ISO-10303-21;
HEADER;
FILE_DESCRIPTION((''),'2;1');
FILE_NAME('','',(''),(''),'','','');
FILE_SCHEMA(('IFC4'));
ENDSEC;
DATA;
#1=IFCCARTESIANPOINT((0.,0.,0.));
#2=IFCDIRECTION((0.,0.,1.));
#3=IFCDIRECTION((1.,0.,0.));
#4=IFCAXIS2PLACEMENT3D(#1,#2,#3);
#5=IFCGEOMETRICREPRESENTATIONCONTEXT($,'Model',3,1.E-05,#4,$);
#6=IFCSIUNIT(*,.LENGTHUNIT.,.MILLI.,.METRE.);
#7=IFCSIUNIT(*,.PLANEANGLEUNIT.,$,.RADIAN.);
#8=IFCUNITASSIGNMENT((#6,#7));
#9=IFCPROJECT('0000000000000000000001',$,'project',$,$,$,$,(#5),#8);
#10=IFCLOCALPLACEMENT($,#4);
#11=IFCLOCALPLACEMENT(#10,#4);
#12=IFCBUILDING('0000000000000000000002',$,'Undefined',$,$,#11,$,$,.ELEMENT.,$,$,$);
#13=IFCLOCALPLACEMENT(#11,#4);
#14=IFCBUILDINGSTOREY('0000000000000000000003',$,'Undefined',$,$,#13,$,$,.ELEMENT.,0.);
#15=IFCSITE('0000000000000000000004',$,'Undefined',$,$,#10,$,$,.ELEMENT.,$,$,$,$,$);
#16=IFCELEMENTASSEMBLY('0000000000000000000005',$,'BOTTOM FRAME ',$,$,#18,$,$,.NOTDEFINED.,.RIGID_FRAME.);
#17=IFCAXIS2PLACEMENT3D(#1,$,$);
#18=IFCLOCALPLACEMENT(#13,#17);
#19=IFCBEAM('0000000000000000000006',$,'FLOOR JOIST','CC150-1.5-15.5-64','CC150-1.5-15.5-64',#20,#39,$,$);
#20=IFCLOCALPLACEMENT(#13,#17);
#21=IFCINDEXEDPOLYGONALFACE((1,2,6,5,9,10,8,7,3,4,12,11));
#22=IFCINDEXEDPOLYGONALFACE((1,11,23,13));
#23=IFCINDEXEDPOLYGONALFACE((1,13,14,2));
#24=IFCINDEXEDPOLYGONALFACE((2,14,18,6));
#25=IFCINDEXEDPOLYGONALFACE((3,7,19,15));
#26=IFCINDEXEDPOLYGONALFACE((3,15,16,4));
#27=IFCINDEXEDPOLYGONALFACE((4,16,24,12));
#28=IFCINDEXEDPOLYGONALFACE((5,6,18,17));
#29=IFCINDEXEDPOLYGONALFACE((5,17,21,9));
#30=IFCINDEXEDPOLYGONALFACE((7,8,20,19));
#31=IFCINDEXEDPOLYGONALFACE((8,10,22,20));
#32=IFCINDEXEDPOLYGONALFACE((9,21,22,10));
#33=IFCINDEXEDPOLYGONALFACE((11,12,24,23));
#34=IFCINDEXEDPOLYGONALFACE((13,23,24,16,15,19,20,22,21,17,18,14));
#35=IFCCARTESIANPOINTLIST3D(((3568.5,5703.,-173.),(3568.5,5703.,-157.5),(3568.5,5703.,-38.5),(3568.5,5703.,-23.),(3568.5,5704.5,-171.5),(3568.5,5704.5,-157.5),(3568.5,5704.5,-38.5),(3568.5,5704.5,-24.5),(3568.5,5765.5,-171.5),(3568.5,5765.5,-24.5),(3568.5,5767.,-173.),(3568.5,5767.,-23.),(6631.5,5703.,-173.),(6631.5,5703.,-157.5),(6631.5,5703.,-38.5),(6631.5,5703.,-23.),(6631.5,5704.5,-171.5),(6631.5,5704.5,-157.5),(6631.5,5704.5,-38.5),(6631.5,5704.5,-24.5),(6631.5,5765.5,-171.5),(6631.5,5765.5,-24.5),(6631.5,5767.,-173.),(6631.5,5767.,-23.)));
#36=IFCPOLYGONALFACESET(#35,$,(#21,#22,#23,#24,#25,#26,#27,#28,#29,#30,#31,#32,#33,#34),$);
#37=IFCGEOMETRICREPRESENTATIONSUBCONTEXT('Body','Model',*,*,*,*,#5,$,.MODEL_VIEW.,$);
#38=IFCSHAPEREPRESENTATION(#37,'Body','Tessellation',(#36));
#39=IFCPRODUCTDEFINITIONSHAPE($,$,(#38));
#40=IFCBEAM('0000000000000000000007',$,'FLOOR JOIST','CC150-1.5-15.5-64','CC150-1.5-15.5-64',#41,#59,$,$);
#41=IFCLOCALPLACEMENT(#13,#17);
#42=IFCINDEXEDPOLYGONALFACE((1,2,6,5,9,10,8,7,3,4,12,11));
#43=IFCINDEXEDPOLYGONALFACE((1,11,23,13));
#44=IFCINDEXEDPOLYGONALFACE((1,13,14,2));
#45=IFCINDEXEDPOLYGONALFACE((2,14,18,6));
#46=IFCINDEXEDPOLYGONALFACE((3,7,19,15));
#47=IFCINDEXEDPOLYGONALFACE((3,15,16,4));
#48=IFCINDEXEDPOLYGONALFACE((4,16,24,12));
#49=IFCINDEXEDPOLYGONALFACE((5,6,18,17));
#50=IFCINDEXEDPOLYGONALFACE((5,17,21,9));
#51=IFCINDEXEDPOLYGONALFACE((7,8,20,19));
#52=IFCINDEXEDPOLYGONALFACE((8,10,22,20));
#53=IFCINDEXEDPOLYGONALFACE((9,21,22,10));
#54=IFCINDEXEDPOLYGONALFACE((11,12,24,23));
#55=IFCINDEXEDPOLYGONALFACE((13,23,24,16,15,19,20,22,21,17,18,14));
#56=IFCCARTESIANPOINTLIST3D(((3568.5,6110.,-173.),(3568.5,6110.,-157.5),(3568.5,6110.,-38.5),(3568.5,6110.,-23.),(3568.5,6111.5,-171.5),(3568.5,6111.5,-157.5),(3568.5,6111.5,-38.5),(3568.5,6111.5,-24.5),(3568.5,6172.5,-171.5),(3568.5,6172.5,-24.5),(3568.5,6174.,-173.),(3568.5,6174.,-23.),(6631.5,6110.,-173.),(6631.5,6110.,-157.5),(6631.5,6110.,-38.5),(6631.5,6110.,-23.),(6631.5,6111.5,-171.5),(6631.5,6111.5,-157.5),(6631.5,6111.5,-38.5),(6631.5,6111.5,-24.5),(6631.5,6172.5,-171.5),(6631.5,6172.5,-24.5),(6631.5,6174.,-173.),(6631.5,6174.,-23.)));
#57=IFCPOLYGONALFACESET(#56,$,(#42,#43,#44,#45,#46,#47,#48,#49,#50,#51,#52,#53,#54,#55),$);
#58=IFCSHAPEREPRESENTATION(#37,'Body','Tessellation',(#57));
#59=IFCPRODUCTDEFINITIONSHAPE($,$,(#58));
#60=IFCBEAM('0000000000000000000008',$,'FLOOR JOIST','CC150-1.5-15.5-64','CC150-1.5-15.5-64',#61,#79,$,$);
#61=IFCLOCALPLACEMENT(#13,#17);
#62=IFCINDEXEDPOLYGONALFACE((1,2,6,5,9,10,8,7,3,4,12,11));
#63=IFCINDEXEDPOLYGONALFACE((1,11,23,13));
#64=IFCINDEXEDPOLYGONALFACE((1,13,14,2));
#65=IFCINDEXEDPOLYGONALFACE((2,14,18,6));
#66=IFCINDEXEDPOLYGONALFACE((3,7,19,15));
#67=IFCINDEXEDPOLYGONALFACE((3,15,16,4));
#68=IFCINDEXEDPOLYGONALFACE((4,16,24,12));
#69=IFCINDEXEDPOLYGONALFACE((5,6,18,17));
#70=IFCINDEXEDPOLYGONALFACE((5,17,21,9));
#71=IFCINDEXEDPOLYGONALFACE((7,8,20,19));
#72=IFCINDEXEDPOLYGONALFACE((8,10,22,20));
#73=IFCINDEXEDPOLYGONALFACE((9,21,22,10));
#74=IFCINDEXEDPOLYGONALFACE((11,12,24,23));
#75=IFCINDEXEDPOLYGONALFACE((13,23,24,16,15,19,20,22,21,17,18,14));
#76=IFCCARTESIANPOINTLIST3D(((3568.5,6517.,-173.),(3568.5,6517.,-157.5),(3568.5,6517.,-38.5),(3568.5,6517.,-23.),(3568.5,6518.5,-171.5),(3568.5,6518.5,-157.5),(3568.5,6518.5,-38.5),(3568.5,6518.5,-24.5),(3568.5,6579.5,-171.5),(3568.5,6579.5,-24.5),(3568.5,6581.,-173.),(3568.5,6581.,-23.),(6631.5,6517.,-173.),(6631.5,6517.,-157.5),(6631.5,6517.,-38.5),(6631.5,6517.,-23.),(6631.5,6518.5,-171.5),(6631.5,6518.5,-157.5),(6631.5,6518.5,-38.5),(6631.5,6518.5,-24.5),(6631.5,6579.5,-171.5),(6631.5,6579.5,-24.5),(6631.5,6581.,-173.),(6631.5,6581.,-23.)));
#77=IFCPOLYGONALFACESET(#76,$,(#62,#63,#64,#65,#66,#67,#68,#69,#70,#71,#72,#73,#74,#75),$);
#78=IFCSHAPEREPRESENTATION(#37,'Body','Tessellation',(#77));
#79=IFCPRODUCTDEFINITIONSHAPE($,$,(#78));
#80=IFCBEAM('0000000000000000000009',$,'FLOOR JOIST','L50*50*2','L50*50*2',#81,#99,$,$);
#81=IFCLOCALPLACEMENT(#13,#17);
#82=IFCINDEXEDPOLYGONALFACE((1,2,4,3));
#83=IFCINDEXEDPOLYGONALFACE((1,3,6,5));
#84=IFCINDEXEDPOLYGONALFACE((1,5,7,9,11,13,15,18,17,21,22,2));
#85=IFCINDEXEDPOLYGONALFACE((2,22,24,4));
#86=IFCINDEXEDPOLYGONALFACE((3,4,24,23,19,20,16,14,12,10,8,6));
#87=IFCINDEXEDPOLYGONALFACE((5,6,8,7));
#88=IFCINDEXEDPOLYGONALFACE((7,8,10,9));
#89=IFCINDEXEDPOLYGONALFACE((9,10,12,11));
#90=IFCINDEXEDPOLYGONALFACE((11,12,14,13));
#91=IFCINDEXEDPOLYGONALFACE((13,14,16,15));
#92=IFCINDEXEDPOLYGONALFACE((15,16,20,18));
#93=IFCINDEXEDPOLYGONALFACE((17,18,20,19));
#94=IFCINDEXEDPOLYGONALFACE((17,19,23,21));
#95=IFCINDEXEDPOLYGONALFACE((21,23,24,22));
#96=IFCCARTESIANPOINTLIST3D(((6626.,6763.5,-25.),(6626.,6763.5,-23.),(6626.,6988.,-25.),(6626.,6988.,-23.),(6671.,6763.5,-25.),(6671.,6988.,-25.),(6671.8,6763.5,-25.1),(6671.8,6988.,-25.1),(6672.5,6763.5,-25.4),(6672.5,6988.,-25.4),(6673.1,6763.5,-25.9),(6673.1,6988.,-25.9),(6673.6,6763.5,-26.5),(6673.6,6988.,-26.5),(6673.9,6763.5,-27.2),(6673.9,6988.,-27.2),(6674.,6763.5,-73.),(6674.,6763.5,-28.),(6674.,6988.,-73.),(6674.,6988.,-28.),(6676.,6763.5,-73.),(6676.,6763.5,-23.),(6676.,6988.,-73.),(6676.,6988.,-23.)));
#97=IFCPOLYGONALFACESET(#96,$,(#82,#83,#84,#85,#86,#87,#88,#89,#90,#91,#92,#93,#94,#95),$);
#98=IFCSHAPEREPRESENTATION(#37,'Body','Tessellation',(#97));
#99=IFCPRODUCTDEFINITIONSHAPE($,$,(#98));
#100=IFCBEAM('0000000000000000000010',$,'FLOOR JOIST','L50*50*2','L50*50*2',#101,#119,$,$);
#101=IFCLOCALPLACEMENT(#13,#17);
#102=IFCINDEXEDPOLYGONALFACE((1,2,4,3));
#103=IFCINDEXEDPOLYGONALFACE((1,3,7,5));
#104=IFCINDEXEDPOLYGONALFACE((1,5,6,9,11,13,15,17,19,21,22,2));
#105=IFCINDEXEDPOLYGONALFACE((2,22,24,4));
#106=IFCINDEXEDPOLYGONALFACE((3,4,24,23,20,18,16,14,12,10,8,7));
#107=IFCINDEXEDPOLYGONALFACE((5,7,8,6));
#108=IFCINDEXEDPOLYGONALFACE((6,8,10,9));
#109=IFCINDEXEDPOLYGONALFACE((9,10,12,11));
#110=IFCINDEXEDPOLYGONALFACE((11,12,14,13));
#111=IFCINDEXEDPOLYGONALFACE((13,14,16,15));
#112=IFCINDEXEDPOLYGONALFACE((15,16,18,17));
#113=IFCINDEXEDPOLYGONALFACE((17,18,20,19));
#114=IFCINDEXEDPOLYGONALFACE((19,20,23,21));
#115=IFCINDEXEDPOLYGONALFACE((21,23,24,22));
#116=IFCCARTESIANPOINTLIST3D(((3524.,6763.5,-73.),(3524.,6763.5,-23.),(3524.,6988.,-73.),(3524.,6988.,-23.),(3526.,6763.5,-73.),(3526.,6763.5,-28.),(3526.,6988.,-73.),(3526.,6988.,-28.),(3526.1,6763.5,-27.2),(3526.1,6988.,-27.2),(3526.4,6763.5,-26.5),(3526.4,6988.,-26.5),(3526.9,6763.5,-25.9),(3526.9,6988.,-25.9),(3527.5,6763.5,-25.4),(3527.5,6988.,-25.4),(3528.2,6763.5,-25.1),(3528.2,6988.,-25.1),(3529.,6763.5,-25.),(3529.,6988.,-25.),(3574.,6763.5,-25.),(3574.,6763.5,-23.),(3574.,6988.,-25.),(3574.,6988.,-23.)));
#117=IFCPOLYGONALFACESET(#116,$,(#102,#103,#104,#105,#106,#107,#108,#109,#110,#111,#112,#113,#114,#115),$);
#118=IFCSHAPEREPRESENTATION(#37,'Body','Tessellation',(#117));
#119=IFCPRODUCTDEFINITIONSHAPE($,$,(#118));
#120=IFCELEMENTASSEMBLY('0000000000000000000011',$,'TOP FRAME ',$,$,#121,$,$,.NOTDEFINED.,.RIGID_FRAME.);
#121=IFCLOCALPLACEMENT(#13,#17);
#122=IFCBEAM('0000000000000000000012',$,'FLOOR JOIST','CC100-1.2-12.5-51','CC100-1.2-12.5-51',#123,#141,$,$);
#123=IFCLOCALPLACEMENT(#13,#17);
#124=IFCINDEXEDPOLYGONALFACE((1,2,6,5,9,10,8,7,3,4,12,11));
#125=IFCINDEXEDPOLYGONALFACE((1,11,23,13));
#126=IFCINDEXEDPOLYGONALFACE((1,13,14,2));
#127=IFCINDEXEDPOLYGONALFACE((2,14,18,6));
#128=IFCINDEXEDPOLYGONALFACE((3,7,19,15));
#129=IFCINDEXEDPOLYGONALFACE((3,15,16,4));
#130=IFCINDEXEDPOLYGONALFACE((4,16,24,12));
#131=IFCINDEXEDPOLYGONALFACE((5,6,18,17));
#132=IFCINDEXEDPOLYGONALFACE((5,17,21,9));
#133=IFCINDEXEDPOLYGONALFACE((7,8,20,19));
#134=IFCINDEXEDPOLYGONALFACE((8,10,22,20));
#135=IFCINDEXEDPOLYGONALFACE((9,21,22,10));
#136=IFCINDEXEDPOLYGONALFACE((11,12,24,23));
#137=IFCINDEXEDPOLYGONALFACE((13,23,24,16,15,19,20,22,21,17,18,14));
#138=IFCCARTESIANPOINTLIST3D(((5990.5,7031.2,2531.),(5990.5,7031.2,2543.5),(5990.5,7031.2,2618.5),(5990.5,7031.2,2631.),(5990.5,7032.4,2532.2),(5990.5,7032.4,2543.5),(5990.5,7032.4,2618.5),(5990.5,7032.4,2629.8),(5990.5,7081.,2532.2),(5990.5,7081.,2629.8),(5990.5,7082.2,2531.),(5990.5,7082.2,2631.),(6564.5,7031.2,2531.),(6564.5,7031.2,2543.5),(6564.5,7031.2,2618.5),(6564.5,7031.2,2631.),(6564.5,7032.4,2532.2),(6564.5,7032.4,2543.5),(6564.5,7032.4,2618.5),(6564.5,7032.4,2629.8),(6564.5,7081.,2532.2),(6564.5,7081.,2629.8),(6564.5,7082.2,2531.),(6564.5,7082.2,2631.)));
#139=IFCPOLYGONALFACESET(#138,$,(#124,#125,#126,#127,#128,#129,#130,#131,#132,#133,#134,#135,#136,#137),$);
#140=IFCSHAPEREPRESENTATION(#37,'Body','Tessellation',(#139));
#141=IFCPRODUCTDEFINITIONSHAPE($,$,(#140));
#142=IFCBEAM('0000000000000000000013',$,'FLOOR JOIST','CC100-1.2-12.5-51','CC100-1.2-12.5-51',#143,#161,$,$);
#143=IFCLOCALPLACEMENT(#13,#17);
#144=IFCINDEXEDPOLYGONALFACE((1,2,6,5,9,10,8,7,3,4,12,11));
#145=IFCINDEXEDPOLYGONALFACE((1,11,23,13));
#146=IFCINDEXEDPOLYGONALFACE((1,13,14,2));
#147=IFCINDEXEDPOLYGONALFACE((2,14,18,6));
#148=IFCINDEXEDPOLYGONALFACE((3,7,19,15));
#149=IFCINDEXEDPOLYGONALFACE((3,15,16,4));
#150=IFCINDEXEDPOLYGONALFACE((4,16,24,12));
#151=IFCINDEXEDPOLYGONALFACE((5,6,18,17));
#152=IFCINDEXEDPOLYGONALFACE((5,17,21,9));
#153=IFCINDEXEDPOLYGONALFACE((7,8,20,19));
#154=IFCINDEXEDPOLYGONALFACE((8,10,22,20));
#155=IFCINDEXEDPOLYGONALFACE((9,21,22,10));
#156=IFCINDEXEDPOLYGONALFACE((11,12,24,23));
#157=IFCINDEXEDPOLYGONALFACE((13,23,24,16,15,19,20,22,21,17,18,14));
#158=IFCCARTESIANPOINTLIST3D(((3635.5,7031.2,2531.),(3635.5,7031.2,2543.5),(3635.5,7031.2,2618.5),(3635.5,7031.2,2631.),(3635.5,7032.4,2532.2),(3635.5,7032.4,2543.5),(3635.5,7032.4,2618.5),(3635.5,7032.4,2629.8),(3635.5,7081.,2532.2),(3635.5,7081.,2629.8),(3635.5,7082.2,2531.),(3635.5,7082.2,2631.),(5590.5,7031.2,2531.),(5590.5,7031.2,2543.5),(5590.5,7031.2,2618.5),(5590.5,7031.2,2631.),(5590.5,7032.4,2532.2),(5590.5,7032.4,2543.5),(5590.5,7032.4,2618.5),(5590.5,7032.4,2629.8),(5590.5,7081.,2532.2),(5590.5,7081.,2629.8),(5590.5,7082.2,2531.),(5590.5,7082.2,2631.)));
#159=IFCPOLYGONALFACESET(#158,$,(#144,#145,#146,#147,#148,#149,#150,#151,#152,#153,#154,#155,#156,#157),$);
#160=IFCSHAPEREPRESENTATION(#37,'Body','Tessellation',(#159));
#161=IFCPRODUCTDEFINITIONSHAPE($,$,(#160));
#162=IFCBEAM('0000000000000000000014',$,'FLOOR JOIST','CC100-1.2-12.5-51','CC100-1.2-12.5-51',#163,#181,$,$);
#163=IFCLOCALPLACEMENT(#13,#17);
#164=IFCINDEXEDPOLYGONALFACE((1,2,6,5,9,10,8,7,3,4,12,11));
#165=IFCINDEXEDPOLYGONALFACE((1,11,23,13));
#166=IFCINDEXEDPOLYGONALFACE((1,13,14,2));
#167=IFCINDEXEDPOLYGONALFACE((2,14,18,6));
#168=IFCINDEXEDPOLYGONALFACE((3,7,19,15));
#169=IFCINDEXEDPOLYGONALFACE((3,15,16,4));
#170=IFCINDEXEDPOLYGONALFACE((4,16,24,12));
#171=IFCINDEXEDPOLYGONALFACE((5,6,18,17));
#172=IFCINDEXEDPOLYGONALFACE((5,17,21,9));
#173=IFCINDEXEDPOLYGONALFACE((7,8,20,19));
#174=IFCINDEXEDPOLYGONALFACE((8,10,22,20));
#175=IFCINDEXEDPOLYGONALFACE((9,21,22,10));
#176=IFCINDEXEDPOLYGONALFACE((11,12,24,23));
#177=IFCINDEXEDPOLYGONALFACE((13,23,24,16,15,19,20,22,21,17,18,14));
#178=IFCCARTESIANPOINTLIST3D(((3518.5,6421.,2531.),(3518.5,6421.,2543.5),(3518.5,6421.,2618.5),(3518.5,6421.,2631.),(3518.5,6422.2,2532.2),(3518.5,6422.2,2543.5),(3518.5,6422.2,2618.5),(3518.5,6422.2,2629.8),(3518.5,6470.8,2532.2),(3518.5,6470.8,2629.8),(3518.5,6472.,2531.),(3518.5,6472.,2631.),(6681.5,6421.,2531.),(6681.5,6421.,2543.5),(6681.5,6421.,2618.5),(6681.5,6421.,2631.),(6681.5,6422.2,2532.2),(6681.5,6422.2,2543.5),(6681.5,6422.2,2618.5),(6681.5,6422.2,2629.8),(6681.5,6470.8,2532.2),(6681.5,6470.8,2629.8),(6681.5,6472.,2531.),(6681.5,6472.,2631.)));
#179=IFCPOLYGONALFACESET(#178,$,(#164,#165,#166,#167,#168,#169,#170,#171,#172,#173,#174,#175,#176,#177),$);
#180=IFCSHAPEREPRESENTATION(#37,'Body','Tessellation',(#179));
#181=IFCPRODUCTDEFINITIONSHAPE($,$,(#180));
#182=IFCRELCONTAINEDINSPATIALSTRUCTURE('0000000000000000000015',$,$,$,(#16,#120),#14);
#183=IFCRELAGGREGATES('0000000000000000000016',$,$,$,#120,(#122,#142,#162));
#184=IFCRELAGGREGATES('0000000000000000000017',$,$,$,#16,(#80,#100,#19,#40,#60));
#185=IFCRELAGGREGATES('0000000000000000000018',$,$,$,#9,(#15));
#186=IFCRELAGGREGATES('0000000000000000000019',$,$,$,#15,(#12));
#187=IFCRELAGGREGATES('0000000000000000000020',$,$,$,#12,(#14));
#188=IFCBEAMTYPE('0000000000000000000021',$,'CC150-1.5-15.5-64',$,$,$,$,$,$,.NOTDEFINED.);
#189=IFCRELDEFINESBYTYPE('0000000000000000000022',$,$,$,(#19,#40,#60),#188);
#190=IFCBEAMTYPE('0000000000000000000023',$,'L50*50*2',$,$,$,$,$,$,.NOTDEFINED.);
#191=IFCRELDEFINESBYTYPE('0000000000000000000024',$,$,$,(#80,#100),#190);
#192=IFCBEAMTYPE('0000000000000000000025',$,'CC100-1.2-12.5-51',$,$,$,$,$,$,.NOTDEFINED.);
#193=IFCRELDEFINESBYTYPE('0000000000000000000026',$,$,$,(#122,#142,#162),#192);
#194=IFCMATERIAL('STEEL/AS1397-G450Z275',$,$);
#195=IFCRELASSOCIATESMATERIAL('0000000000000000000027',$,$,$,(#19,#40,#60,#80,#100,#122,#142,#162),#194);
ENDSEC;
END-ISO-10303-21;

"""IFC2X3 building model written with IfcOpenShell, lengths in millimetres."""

from ifc_helpers import new_model, si_unit, frame, origin_with_axes, origin_2d_with_axis, place, context, subcontext, project, spatial, l_section, c_section, extrude, material, type_object, element, aggregate, save


model = new_model("IFC2X3")

# Units and contexts
model_context = context("Model", 3, precision=1e-05, world=origin_with_axes())
body_context = subcontext(model_context, "Body", "Model", "MODEL_VIEW")
ifc_project = project(units=[si_unit("LENGTHUNIT", "METRE", prefix="MILLI"), si_unit("PLANEANGLEUNIT", "RADIAN")], contexts=[model_context])

# Site, building, storey
site_placement = place(None, origin_with_axes())
site = spatial("IfcSite", under=ifc_project, at=site_placement, Name="Undefined", CompositionType="ELEMENT")
building_placement = place(site_placement, origin_with_axes())
building = spatial("IfcBuilding", under=site, at=building_placement, Name="Undefined", CompositionType="ELEMENT")
storey_placement = place(building_placement, origin_with_axes())
storey = spatial("IfcBuildingStorey", under=building, at=storey_placement, Name="Undefined", CompositionType="ELEMENT", Elevation=0.0)

# Element assemblies, beams
assembly_1_placement = place(storey_placement, origin_with_axes())
assembly_1 = element("IfcElementAssembly", 1, at=assembly_1_placement, inside=storey, Name="BOTTOM FRAME ", AssemblyPlace="NOTDEFINED", PredefinedType="RIGID_FRAME")
ifc_material_1 = material(Name="STEEL/AS1397-G450Z275")
beam_type_1 = type_object("IfcBeamType", Name="CC150-1.5-15.5-64", PredefinedType="NOTDEFINED")
beam_1_placement = place(assembly_1_placement, frame((3568.5, 5735.0, -98.0), z_axis=(0.0, 0.0, 1.0), x_axis=(1.0, 0.0, 0.0)))
beam_1 = element("IfcBeam", 2, at=beam_1_placement, type_object=beam_type_1, material=ifc_material_1, Name="FLOOR JOIST", Description="CC150-1.5-15.5-64", ObjectType="CC150-1.5-15.5-64", context=body_context, shape_type="SweptSolid", body=[
    extrude(c_section(Depth=150.0, Width=64.0, WallThickness=1.5, Girth=15.5, at=origin_2d_with_axis()), frame((3063.0, 0.0, 0.0), z_axis=(-1.0, 0.0, 0.0), x_axis=(0.0, -1.0, 0.0)), (0.0, 0.0, 1.0), 3063.0),
])
beam_2_placement = place(assembly_1_placement, frame((3568.5, 6142.0, -98.0), z_axis=(0.0, 0.0, 1.0), x_axis=(1.0, 0.0, 0.0)))
beam_2 = element("IfcBeam", 3, at=beam_2_placement, type_object=beam_type_1, material=ifc_material_1, Name="FLOOR JOIST", Description="CC150-1.5-15.5-64", ObjectType="CC150-1.5-15.5-64", context=body_context, shape_type="SweptSolid", body=[
    extrude(c_section(Depth=150.0, Width=64.0, WallThickness=1.5, Girth=15.5, at=origin_2d_with_axis()), frame((3063.0, 0.0, 0.0), z_axis=(-1.0, 0.0, 0.0), x_axis=(0.0, -1.0, 0.0)), (0.0, 0.0, 1.0), 3063.0),
])
beam_3_placement = place(assembly_1_placement, frame((3568.5, 6549.0, -98.0), z_axis=(0.0, 0.0, 1.0), x_axis=(1.0, 0.0, 0.0)))
beam_3 = element("IfcBeam", 4, at=beam_3_placement, type_object=beam_type_1, material=ifc_material_1, Name="FLOOR JOIST", Description="CC150-1.5-15.5-64", ObjectType="CC150-1.5-15.5-64", context=body_context, shape_type="SweptSolid", body=[
    extrude(c_section(Depth=150.0, Width=64.0, WallThickness=1.5, Girth=15.5, at=origin_2d_with_axis()), frame((3063.0, 0.0, 0.0), z_axis=(-1.0, 0.0, 0.0), x_axis=(0.0, -1.0, 0.0)), (0.0, 0.0, 1.0), 3063.0),
])
beam_type_2 = type_object("IfcBeamType", Name="L50*50*2", PredefinedType="NOTDEFINED")
beam_4_placement = place(assembly_1_placement, frame((6651.0, 6988.0, -48.0), z_axis=(-1.0, 0.0, 0.0), x_axis=(0.0, -1.0, 0.0)))
beam_4 = element("IfcBeam", 5, at=beam_4_placement, type_object=beam_type_2, material=ifc_material_1, Name="FLOOR JOIST", Description="L50*50*2", ObjectType="L50*50*2", context=body_context, shape_type="SweptSolid", body=[
    extrude(l_section(Depth=50.0, Width=50.0, Thickness=2.0, FilletRadius=3.0, at=origin_2d_with_axis()), frame((224.5, 0.0, 0.0), z_axis=(-1.0, 0.0, 0.0), x_axis=(0.0, -1.0, 0.0)), (0.0, 0.0, 1.0), 224.5),
])
beam_5_placement = place(assembly_1_placement, frame((3549.0, 6763.5, -48.0), z_axis=(1.0, 0.0, 0.0), x_axis=(0.0, 1.0, 0.0)))
beam_5 = element("IfcBeam", 6, at=beam_5_placement, type_object=beam_type_2, material=ifc_material_1, Name="FLOOR JOIST", Description="L50*50*2", ObjectType="L50*50*2", context=body_context, shape_type="SweptSolid", body=[
    extrude(l_section(Depth=50.0, Width=50.0, Thickness=2.0, FilletRadius=3.0, at=origin_2d_with_axis()), frame((224.5, 0.0, 0.0), z_axis=(-1.0, 0.0, 0.0), x_axis=(0.0, -1.0, 0.0)), (0.0, 0.0, 1.0), 224.5),
])
assembly_2_placement = place(storey_placement, origin_with_axes())
assembly_2 = element("IfcElementAssembly", 7, at=assembly_2_placement, inside=storey, Name="TOP FRAME ", AssemblyPlace="NOTDEFINED", PredefinedType="RIGID_FRAME")
beam_type_3 = type_object("IfcBeamType", Name="CC100-1.2-12.5-51", PredefinedType="NOTDEFINED")
beam_6_placement = place(assembly_2_placement, frame((5990.5, 7056.7, 2581.0), z_axis=(0.0, 0.0, 1.0), x_axis=(1.0, 0.0, 0.0)))
beam_6 = element("IfcBeam", 8, at=beam_6_placement, type_object=beam_type_3, material=ifc_material_1, Name="FLOOR JOIST", Description="CC100-1.2-12.5-51", ObjectType="CC100-1.2-12.5-51", context=body_context, shape_type="SweptSolid", body=[
    extrude(c_section(Depth=100.0, Width=51.0, WallThickness=1.2, Girth=12.5, at=origin_2d_with_axis()), frame((574.0, 0.0, 0.0), z_axis=(-1.0, 0.0, 0.0), x_axis=(0.0, -1.0, 0.0)), (0.0, 0.0, 1.0), 574.0),
])
beam_7_placement = place(assembly_2_placement, frame((3635.5, 7056.7, 2581.0), z_axis=(0.0, 0.0, 1.0), x_axis=(1.0, 0.0, 0.0)))
beam_7 = element("IfcBeam", 9, at=beam_7_placement, type_object=beam_type_3, material=ifc_material_1, Name="FLOOR JOIST", Description="CC100-1.2-12.5-51", ObjectType="CC100-1.2-12.5-51", context=body_context, shape_type="SweptSolid", body=[
    extrude(c_section(Depth=100.0, Width=51.0, WallThickness=1.2, Girth=12.5, at=origin_2d_with_axis()), frame((1955.0, 0.0, 0.0), z_axis=(-1.0, 0.0, 0.0), x_axis=(0.0, -1.0, 0.0)), (0.0, 0.0, 1.0), 1955.0),
])
beam_8_placement = place(assembly_2_placement, frame((3518.5, 6446.5, 2581.0), z_axis=(0.0, 0.0, 1.0), x_axis=(1.0, 0.0, 0.0)))
beam_8 = element("IfcBeam", 10, at=beam_8_placement, type_object=beam_type_3, material=ifc_material_1, Name="FLOOR JOIST", Description="CC100-1.2-12.5-51", ObjectType="CC100-1.2-12.5-51", context=body_context, shape_type="SweptSolid", body=[
    extrude(c_section(Depth=100.0, Width=51.0, WallThickness=1.2, Girth=12.5, at=origin_2d_with_axis()), frame((3163.0, 0.0, 0.0), z_axis=(-1.0, 0.0, 0.0), x_axis=(0.0, -1.0, 0.0)), (0.0, 0.0, 1.0), 3163.0),
])

aggregate(assembly_2, [beam_6, beam_7, beam_8])
aggregate(assembly_1, [beam_4, beam_5, beam_1, beam_2, beam_3])

save(model, "model.ifc")
